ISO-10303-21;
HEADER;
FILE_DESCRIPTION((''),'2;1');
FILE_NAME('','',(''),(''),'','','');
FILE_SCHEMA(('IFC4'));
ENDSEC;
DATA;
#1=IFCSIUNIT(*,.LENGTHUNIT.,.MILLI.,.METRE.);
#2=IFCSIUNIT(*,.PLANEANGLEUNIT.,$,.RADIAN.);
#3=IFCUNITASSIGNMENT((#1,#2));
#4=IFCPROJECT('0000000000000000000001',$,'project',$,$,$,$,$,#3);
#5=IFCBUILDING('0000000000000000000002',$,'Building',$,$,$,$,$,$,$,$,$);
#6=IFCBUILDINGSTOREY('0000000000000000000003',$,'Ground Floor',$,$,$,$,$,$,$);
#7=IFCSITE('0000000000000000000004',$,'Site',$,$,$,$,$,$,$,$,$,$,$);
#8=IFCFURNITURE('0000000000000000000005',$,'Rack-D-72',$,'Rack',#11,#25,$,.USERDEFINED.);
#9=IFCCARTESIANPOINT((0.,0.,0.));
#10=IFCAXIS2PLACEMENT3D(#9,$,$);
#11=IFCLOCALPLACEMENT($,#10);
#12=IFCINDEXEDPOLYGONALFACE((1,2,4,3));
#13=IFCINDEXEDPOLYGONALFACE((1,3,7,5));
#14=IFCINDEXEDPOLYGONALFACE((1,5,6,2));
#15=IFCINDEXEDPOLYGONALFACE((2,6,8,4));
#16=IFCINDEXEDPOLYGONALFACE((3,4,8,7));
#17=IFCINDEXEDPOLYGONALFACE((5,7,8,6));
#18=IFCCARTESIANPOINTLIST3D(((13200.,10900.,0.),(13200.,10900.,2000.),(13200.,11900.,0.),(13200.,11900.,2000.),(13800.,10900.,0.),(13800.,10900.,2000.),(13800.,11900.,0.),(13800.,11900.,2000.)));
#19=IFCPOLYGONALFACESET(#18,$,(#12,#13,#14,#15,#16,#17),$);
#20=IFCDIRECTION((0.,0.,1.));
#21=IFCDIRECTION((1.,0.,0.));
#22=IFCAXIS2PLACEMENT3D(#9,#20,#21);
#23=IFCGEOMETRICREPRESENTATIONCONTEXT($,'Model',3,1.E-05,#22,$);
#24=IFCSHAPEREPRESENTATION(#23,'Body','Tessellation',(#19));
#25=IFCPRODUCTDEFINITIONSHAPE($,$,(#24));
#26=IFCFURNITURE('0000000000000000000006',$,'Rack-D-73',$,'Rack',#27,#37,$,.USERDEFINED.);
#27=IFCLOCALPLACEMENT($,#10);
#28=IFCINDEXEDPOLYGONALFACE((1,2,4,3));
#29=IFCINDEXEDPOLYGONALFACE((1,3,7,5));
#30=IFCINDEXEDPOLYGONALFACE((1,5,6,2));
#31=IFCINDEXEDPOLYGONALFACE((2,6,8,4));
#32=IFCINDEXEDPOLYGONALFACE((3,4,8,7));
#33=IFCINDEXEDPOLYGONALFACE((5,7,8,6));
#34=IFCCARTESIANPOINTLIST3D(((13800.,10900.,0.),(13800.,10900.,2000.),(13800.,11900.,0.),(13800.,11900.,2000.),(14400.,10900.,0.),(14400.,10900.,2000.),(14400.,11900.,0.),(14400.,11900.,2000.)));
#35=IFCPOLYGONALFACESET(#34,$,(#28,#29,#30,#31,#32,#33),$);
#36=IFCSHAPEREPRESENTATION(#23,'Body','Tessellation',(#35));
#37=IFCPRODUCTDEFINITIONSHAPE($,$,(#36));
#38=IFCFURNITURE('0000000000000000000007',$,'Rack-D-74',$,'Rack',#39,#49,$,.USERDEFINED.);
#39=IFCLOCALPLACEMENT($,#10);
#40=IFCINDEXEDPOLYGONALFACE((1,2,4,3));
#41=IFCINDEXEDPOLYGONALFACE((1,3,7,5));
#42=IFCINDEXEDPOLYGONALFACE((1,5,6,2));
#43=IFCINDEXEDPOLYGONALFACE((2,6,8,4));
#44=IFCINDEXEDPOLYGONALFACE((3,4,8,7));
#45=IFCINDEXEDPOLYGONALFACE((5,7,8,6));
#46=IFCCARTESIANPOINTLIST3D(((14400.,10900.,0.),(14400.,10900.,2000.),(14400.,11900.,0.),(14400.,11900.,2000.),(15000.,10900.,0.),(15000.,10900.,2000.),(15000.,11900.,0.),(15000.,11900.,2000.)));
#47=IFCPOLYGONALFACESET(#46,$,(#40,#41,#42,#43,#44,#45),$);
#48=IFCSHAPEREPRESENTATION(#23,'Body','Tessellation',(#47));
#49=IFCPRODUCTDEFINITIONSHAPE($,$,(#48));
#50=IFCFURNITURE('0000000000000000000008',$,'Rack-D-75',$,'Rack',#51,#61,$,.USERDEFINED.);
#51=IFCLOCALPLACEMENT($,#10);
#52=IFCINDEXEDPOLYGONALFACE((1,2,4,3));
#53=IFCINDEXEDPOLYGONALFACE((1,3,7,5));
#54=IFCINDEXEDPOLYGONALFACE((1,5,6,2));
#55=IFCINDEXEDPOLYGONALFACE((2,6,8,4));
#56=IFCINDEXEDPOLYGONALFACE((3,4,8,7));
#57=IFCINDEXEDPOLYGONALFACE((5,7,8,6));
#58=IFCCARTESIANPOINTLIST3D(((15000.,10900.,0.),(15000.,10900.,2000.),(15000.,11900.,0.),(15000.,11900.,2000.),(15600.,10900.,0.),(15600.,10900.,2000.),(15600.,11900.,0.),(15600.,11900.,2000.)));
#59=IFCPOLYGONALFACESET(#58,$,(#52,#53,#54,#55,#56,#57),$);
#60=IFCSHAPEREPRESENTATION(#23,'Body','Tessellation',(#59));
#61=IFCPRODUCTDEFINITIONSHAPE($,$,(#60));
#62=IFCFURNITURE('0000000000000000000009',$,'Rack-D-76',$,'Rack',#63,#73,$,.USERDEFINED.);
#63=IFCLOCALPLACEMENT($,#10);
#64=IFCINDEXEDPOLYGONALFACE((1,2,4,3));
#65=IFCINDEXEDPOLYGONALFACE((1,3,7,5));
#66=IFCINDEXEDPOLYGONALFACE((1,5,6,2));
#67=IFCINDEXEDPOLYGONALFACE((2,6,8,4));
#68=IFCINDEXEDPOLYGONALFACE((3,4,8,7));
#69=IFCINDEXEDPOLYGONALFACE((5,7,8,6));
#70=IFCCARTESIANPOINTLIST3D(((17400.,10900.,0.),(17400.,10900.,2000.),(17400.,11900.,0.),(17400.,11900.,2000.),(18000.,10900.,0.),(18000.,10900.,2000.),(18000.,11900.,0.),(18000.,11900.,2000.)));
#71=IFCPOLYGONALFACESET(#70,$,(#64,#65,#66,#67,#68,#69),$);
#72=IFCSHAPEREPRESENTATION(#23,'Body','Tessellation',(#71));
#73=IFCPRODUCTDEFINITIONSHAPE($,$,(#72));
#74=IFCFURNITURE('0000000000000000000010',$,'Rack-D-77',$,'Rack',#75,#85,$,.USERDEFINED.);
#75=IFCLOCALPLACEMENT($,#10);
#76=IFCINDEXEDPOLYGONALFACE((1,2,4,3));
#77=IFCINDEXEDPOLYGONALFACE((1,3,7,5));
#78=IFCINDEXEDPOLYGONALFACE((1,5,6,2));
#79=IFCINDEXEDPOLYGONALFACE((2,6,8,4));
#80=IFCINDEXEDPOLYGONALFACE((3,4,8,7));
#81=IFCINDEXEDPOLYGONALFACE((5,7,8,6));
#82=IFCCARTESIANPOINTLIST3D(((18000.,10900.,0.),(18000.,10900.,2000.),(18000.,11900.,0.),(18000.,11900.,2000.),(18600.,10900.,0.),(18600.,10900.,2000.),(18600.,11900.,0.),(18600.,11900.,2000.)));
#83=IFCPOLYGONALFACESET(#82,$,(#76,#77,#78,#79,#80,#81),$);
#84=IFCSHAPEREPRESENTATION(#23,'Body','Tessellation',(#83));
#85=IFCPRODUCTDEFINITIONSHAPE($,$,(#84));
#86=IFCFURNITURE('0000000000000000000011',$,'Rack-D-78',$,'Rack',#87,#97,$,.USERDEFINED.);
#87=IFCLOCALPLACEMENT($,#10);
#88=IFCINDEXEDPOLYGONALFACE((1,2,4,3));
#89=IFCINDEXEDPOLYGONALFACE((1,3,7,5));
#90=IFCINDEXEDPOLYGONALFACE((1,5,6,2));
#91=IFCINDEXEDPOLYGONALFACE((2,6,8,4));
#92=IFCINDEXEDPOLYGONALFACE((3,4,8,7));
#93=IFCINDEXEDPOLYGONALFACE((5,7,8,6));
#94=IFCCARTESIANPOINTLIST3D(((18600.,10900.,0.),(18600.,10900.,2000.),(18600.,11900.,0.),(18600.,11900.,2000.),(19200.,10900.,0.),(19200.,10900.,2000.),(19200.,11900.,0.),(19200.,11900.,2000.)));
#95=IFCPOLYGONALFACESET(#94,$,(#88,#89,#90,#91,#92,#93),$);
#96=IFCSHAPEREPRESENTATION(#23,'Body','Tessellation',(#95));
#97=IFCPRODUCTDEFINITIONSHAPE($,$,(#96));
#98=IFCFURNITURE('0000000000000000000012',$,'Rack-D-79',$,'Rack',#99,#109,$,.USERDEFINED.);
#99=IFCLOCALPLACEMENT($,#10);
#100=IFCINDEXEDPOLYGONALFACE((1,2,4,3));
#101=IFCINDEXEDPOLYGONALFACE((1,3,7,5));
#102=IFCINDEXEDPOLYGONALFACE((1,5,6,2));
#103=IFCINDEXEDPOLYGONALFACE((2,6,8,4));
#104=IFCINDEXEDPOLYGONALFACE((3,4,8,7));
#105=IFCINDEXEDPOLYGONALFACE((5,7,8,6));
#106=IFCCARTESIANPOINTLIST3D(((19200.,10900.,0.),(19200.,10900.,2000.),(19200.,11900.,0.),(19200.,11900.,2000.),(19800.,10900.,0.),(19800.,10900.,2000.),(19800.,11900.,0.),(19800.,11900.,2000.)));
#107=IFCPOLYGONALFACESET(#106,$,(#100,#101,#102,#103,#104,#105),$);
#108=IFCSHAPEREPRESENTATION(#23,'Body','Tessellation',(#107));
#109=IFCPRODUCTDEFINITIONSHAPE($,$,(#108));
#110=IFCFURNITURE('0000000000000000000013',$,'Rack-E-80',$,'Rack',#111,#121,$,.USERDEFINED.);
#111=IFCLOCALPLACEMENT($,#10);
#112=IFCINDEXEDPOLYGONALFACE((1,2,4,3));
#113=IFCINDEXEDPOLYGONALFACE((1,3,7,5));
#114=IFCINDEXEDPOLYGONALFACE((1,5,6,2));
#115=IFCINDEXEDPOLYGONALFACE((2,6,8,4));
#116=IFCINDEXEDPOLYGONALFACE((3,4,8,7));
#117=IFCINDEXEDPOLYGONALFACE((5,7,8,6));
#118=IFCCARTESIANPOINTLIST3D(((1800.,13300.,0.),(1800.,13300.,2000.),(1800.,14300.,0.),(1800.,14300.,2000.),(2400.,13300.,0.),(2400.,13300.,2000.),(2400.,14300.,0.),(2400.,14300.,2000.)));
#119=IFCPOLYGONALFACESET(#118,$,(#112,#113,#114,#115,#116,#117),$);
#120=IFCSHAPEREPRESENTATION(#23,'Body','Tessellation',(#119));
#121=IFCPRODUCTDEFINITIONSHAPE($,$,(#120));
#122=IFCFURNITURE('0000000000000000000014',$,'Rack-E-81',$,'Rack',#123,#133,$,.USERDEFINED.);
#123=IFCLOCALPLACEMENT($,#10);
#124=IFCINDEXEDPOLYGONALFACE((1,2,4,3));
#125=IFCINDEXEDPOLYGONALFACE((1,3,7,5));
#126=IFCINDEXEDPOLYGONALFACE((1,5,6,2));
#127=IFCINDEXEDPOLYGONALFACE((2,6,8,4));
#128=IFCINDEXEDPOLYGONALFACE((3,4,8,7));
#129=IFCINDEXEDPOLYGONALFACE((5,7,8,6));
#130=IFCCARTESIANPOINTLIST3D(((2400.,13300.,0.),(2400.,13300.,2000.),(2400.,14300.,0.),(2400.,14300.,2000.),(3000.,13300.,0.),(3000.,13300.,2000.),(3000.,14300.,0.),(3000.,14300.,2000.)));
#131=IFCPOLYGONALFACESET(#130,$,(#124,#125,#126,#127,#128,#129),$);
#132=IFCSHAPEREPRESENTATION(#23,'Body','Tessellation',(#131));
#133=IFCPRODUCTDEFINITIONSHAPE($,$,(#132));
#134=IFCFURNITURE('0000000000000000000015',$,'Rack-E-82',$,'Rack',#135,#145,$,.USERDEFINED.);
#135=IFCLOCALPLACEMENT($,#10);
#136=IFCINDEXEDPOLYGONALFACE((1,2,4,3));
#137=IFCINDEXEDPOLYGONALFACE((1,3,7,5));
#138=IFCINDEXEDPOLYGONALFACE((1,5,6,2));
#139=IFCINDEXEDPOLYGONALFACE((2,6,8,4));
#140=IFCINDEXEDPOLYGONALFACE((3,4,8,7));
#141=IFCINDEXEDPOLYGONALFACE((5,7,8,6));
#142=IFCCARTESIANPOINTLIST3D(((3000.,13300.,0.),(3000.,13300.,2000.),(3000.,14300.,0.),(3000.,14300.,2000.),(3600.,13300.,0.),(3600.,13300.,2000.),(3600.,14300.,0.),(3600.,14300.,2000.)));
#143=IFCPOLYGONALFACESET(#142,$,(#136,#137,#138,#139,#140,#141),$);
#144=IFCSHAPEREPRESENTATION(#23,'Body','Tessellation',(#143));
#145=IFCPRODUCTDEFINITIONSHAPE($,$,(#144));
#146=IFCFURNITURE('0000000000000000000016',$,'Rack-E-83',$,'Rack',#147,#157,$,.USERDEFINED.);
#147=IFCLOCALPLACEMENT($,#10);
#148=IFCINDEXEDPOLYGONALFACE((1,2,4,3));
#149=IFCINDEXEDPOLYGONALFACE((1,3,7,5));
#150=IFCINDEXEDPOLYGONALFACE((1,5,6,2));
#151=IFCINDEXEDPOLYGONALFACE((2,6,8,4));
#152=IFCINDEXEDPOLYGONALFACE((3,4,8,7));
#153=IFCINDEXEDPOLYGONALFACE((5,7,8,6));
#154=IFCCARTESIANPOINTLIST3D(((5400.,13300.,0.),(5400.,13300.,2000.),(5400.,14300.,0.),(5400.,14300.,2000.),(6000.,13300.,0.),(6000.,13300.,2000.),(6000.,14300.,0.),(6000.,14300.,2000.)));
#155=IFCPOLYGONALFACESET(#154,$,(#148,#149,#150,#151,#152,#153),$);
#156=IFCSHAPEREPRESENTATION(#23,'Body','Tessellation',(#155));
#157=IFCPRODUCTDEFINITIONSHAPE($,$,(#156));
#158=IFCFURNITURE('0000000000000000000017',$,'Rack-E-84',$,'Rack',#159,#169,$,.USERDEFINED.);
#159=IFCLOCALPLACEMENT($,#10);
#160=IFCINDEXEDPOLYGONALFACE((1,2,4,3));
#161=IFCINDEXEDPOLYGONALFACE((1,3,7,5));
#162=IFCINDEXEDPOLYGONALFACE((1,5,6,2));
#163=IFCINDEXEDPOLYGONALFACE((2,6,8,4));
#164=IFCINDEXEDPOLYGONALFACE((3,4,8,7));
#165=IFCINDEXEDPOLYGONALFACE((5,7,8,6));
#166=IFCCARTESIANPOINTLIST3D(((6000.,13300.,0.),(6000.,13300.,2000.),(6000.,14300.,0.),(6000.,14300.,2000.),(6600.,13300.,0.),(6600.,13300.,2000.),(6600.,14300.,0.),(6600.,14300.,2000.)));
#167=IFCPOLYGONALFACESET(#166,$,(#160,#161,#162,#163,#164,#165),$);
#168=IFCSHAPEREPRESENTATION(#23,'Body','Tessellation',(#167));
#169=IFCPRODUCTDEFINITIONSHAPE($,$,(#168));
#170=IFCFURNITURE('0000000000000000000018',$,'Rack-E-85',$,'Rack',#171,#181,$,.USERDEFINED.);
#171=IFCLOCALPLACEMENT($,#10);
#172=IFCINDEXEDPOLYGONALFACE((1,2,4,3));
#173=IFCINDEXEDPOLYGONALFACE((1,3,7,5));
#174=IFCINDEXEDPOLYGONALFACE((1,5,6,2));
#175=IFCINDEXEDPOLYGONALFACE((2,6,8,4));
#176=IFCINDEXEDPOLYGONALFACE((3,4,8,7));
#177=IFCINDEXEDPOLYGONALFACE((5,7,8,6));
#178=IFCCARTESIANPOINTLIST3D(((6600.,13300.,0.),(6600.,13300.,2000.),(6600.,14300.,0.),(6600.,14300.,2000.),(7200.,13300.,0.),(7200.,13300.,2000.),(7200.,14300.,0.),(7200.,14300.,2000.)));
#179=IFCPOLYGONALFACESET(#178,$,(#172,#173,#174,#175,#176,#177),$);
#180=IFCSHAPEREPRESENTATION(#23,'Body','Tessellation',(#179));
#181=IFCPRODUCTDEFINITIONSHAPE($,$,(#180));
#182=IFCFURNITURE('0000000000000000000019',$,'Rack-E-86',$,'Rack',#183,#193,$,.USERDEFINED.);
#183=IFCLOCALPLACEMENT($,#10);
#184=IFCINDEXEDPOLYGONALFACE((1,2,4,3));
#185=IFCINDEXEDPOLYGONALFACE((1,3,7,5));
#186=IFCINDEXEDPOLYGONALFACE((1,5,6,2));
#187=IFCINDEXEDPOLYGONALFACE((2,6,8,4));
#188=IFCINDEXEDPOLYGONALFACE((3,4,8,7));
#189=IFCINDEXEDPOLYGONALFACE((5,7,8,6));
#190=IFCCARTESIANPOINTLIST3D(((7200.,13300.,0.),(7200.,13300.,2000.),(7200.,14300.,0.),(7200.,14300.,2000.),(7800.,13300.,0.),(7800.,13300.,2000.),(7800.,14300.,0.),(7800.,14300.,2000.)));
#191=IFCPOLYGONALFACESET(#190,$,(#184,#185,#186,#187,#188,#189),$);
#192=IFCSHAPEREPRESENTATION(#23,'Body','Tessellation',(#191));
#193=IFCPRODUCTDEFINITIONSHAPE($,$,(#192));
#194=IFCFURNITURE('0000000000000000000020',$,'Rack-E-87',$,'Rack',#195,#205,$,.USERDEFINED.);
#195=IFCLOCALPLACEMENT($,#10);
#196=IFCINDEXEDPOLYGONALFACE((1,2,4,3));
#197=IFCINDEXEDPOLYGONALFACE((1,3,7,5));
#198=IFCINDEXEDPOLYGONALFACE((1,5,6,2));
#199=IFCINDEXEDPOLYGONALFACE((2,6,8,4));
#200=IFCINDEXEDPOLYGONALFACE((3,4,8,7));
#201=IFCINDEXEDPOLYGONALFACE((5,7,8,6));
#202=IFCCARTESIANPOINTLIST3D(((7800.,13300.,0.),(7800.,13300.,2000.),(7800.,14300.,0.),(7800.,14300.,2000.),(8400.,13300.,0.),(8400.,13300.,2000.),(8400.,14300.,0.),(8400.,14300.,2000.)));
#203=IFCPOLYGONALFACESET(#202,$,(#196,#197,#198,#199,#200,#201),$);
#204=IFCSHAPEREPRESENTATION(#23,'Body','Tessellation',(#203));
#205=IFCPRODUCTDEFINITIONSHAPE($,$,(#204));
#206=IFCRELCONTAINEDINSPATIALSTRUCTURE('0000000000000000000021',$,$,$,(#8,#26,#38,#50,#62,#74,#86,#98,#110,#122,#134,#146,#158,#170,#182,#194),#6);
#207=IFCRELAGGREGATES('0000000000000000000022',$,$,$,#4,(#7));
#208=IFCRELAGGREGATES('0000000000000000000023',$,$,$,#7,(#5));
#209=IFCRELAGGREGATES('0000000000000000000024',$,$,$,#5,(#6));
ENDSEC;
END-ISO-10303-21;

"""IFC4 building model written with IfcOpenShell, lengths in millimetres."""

from ifc_helpers import new_model, si_unit, frame, origin_with_axes, place, context, project, spatial, rectangle, extrude, element, save


model = new_model("IFC4")

# Units and contexts
model_context = context("Model", 3, precision=1e-05, world=origin_with_axes())
ifc_project = project(units=[si_unit("LENGTHUNIT", "METRE", prefix="MILLI"), si_unit("PLANEANGLEUNIT", "RADIAN")])

# Site, building, storey
site = spatial("IfcSite", under=ifc_project, Name="Site")
building = spatial("IfcBuilding", under=site, Name="Building")
storey = spatial("IfcBuildingStorey", under=building, Name="Ground Floor")

# Furniture
furniture_1_placement = place(None, origin_with_axes())
element("IfcFurniture", 1, at=furniture_1_placement, inside=storey, Name="Rack-D-72", ObjectType="Rack", PredefinedType="USERDEFINED", context=model_context, shape_type="SweptSolid", body=[
    extrude(rectangle(XDim=600.0, YDim=1000.0), frame((13500.0, 11400.0, 0.0), z_axis=(0.0, 0.0, 1.0), x_axis=(1.0, 0.0, 0.0)), (0.0, 0.0, 1.0), 2000.0),
])
furniture_2_placement = place(None, origin_with_axes())
element("IfcFurniture", 2, at=furniture_2_placement, inside=storey, Name="Rack-D-73", ObjectType="Rack", PredefinedType="USERDEFINED", context=model_context, shape_type="SweptSolid", body=[
    extrude(rectangle(XDim=600.0, YDim=1000.0), frame((14100.0, 11400.0, 0.0), z_axis=(0.0, 0.0, 1.0), x_axis=(1.0, 0.0, 0.0)), (0.0, 0.0, 1.0), 2000.0),
])
furniture_3_placement = place(None, origin_with_axes())
element("IfcFurniture", 3, at=furniture_3_placement, inside=storey, Name="Rack-D-74", ObjectType="Rack", PredefinedType="USERDEFINED", context=model_context, shape_type="SweptSolid", body=[
    extrude(rectangle(XDim=600.0, YDim=1000.0), frame((14700.0, 11400.0, 0.0), z_axis=(0.0, 0.0, 1.0), x_axis=(1.0, 0.0, 0.0)), (0.0, 0.0, 1.0), 2000.0),
])
furniture_4_placement = place(None, origin_with_axes())
element("IfcFurniture", 4, at=furniture_4_placement, inside=storey, Name="Rack-D-75", ObjectType="Rack", PredefinedType="USERDEFINED", context=model_context, shape_type="SweptSolid", body=[
    extrude(rectangle(XDim=600.0, YDim=1000.0), frame((15300.0, 11400.0, 0.0), z_axis=(0.0, 0.0, 1.0), x_axis=(1.0, 0.0, 0.0)), (0.0, 0.0, 1.0), 2000.0),
])
furniture_5_placement = place(None, origin_with_axes())
element("IfcFurniture", 5, at=furniture_5_placement, inside=storey, Name="Rack-D-76", ObjectType="Rack", PredefinedType="USERDEFINED", context=model_context, shape_type="SweptSolid", body=[
    extrude(rectangle(XDim=600.0, YDim=1000.0), frame((17700.0, 11400.0, 0.0), z_axis=(0.0, 0.0, 1.0), x_axis=(1.0, 0.0, 0.0)), (0.0, 0.0, 1.0), 2000.0),
])
furniture_6_placement = place(None, origin_with_axes())
element("IfcFurniture", 6, at=furniture_6_placement, inside=storey, Name="Rack-D-77", ObjectType="Rack", PredefinedType="USERDEFINED", context=model_context, shape_type="SweptSolid", body=[
    extrude(rectangle(XDim=600.0, YDim=1000.0), frame((18300.0, 11400.0, 0.0), z_axis=(0.0, 0.0, 1.0), x_axis=(1.0, 0.0, 0.0)), (0.0, 0.0, 1.0), 2000.0),
])
furniture_7_placement = place(None, origin_with_axes())
element("IfcFurniture", 7, at=furniture_7_placement, inside=storey, Name="Rack-D-78", ObjectType="Rack", PredefinedType="USERDEFINED", context=model_context, shape_type="SweptSolid", body=[
    extrude(rectangle(XDim=600.0, YDim=1000.0), frame((18900.0, 11400.0, 0.0), z_axis=(0.0, 0.0, 1.0), x_axis=(1.0, 0.0, 0.0)), (0.0, 0.0, 1.0), 2000.0),
])
furniture_8_placement = place(None, origin_with_axes())
element("IfcFurniture", 8, at=furniture_8_placement, inside=storey, Name="Rack-D-79", ObjectType="Rack", PredefinedType="USERDEFINED", context=model_context, shape_type="SweptSolid", body=[
    extrude(rectangle(XDim=600.0, YDim=1000.0), frame((19500.0, 11400.0, 0.0), z_axis=(0.0, 0.0, 1.0), x_axis=(1.0, 0.0, 0.0)), (0.0, 0.0, 1.0), 2000.0),
])
furniture_9_placement = place(None, origin_with_axes())
element("IfcFurniture", 9, at=furniture_9_placement, inside=storey, Name="Rack-E-80", ObjectType="Rack", PredefinedType="USERDEFINED", context=model_context, shape_type="SweptSolid", body=[
    extrude(rectangle(XDim=600.0, YDim=1000.0), frame((2100.0, 13800.0, 0.0), z_axis=(0.0, 0.0, 1.0), x_axis=(1.0, 0.0, 0.0)), (0.0, 0.0, 1.0), 2000.0),
])
furniture_10_placement = place(None, origin_with_axes())
element("IfcFurniture", 10, at=furniture_10_placement, inside=storey, Name="Rack-E-81", ObjectType="Rack", PredefinedType="USERDEFINED", context=model_context, shape_type="SweptSolid", body=[
    extrude(rectangle(XDim=600.0, YDim=1000.0), frame((2700.0, 13800.0, 0.0), z_axis=(0.0, 0.0, 1.0), x_axis=(1.0, 0.0, 0.0)), (0.0, 0.0, 1.0), 2000.0),
])
furniture_11_placement = place(None, origin_with_axes())
element("IfcFurniture", 11, at=furniture_11_placement, inside=storey, Name="Rack-E-82", ObjectType="Rack", PredefinedType="USERDEFINED", context=model_context, shape_type="SweptSolid", body=[
    extrude(rectangle(XDim=600.0, YDim=1000.0), frame((3300.0, 13800.0, 0.0), z_axis=(0.0, 0.0, 1.0), x_axis=(1.0, 0.0, 0.0)), (0.0, 0.0, 1.0), 2000.0),
])
furniture_12_placement = place(None, origin_with_axes())
element("IfcFurniture", 12, at=furniture_12_placement, inside=storey, Name="Rack-E-83", ObjectType="Rack", PredefinedType="USERDEFINED", context=model_context, shape_type="SweptSolid", body=[
    extrude(rectangle(XDim=600.0, YDim=1000.0), frame((5700.0, 13800.0, 0.0), z_axis=(0.0, 0.0, 1.0), x_axis=(1.0, 0.0, 0.0)), (0.0, 0.0, 1.0), 2000.0),
])
furniture_13_placement = place(None, origin_with_axes())
element("IfcFurniture", 13, at=furniture_13_placement, inside=storey, Name="Rack-E-84", ObjectType="Rack", PredefinedType="USERDEFINED", context=model_context, shape_type="SweptSolid", body=[
    extrude(rectangle(XDim=600.0, YDim=1000.0), frame((6300.0, 13800.0, 0.0), z_axis=(0.0, 0.0, 1.0), x_axis=(1.0, 0.0, 0.0)), (0.0, 0.0, 1.0), 2000.0),
])
furniture_14_placement = place(None, origin_with_axes())
element("IfcFurniture", 14, at=furniture_14_placement, inside=storey, Name="Rack-E-85", ObjectType="Rack", PredefinedType="USERDEFINED", context=model_context, shape_type="SweptSolid", body=[
    extrude(rectangle(XDim=600.0, YDim=1000.0), frame((6900.0, 13800.0, 0.0), z_axis=(0.0, 0.0, 1.0), x_axis=(1.0, 0.0, 0.0)), (0.0, 0.0, 1.0), 2000.0),
])
furniture_15_placement = place(None, origin_with_axes())
element("IfcFurniture", 15, at=furniture_15_placement, inside=storey, Name="Rack-E-86", ObjectType="Rack", PredefinedType="USERDEFINED", context=model_context, shape_type="SweptSolid", body=[
    extrude(rectangle(XDim=600.0, YDim=1000.0), frame((7500.0, 13800.0, 0.0), z_axis=(0.0, 0.0, 1.0), x_axis=(1.0, 0.0, 0.0)), (0.0, 0.0, 1.0), 2000.0),
])
furniture_16_placement = place(None, origin_with_axes())
element("IfcFurniture", 16, at=furniture_16_placement, inside=storey, Name="Rack-E-87", ObjectType="Rack", PredefinedType="USERDEFINED", context=model_context, shape_type="SweptSolid", body=[
    extrude(rectangle(XDim=600.0, YDim=1000.0), frame((8100.0, 13800.0, 0.0), z_axis=(0.0, 0.0, 1.0), x_axis=(1.0, 0.0, 0.0)), (0.0, 0.0, 1.0), 2000.0),
])

save(model, "model.ifc")
